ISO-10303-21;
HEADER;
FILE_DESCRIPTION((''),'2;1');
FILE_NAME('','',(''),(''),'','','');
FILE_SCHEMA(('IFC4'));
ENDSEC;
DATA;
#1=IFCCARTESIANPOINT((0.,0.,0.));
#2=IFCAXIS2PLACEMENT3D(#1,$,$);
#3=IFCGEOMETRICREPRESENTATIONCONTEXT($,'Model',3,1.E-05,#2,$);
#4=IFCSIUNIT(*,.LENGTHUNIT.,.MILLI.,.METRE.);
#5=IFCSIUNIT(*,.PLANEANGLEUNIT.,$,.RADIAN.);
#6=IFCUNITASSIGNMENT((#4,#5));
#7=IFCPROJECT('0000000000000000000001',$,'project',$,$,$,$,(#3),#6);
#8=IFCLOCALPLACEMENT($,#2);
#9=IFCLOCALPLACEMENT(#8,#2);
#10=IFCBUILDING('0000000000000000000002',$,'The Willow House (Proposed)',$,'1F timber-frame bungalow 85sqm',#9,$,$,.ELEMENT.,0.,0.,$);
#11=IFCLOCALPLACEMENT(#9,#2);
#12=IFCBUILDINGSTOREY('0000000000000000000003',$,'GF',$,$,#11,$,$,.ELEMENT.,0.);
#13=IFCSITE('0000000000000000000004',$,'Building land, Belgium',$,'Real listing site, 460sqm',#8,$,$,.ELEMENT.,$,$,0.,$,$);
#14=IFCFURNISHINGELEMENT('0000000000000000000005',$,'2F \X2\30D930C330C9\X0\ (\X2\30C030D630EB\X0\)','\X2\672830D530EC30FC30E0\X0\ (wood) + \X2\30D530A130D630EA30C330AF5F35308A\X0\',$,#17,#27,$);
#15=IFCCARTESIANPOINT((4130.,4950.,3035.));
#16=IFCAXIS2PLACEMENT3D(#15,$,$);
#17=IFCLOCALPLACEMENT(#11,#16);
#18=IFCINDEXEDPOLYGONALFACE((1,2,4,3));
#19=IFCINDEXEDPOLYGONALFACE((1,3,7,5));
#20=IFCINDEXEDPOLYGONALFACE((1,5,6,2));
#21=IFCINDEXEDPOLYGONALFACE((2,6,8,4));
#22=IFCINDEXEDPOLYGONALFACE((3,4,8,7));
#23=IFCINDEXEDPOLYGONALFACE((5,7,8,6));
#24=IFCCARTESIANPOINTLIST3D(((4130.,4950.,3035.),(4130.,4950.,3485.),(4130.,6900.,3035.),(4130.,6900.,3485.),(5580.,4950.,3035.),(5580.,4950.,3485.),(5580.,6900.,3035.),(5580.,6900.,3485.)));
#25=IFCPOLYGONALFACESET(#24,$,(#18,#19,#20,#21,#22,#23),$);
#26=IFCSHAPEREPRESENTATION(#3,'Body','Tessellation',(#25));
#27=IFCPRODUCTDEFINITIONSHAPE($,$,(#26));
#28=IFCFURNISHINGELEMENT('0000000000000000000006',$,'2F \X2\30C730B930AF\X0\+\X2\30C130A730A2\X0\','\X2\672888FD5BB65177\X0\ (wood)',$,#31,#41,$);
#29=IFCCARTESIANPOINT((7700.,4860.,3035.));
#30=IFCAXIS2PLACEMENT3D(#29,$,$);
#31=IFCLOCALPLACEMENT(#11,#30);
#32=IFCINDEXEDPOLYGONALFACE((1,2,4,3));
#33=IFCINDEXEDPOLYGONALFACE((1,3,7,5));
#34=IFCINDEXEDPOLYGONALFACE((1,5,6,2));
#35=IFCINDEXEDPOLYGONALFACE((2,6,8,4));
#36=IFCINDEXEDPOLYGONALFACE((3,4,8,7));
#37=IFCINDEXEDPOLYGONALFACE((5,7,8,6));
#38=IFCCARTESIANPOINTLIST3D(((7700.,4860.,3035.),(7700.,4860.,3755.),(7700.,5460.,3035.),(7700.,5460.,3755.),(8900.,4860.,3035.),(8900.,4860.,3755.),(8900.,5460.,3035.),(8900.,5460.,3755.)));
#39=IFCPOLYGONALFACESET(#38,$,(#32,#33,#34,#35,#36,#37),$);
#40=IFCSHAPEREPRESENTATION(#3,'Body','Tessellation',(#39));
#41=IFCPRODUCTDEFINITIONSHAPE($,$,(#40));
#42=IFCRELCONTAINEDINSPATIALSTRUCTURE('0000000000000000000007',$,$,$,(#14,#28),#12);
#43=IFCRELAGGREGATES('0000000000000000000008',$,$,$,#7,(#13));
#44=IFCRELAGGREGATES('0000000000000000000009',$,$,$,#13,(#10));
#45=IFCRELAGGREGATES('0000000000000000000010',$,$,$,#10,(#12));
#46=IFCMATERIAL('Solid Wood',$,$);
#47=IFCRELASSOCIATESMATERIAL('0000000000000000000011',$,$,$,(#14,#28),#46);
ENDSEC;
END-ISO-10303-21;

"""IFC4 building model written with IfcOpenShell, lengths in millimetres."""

from ifc_helpers import new_model, si_unit, frame, frame_2d, origin, place, context, project, spatial, rectangle, extrude, material, element, save


model = new_model("IFC4")

# Units and contexts
model_context = context("Model", 3, precision=1e-05, world=origin())
ifc_project = project(units=[si_unit("LENGTHUNIT", "METRE", prefix="MILLI"), si_unit("PLANEANGLEUNIT", "RADIAN")], contexts=[model_context])

# Site, building, storey
site_placement = place(None, origin())
site = spatial("IfcSite", under=ifc_project, at=site_placement, Name="Building land, Belgium", ObjectType="Real listing site, 460sqm", CompositionType="ELEMENT", RefElevation=0.0)
building_placement = place(site_placement, origin())
building = spatial("IfcBuilding", under=site, at=building_placement, Name="The Willow House (Proposed)", ObjectType="1F timber-frame bungalow 85sqm", CompositionType="ELEMENT", ElevationOfRefHeight=0.0, ElevationOfTerrain=0.0)
storey_placement = place(building_placement, origin())
storey = spatial("IfcBuildingStorey", under=building, at=storey_placement, Name="GF", CompositionType="ELEMENT", Elevation=0.0)

# Shared definitions
ifc_material_1 = material(Name="Solid Wood")

# Furnishing elements
furnishing_1_placement = place(storey_placement, frame((4130.0, 4950.0, 3035.0)))
element("IfcFurnishingElement", 1, at=furnishing_1_placement, inside=storey, material=ifc_material_1, Name="2F ベッド (ダブル)", Description="木フレーム (wood) + ファブリック張り", context=model_context, shape_type="SweptSolid", body=[
    extrude(rectangle(XDim=1450.0, YDim=1950.0, at=frame_2d((725.0, 975.0))), frame((4130.0, 4950.0, 3035.0)), (0.0, 0.0, 1.0), 450.0),
])
furnishing_2_placement = place(storey_placement, frame((7700.0, 4860.0, 3035.0)))
element("IfcFurnishingElement", 2, at=furnishing_2_placement, inside=storey, material=ifc_material_1, Name="2F デスク+チェア", Description="木製家具 (wood)", context=model_context, shape_type="SweptSolid", body=[
    extrude(rectangle(XDim=1200.0, YDim=600.0, at=frame_2d((600.0, 300.0))), frame((7700.0, 4860.0, 3035.0)), (0.0, 0.0, 1.0), 720.0),
])

save(model, "model.ifc")
